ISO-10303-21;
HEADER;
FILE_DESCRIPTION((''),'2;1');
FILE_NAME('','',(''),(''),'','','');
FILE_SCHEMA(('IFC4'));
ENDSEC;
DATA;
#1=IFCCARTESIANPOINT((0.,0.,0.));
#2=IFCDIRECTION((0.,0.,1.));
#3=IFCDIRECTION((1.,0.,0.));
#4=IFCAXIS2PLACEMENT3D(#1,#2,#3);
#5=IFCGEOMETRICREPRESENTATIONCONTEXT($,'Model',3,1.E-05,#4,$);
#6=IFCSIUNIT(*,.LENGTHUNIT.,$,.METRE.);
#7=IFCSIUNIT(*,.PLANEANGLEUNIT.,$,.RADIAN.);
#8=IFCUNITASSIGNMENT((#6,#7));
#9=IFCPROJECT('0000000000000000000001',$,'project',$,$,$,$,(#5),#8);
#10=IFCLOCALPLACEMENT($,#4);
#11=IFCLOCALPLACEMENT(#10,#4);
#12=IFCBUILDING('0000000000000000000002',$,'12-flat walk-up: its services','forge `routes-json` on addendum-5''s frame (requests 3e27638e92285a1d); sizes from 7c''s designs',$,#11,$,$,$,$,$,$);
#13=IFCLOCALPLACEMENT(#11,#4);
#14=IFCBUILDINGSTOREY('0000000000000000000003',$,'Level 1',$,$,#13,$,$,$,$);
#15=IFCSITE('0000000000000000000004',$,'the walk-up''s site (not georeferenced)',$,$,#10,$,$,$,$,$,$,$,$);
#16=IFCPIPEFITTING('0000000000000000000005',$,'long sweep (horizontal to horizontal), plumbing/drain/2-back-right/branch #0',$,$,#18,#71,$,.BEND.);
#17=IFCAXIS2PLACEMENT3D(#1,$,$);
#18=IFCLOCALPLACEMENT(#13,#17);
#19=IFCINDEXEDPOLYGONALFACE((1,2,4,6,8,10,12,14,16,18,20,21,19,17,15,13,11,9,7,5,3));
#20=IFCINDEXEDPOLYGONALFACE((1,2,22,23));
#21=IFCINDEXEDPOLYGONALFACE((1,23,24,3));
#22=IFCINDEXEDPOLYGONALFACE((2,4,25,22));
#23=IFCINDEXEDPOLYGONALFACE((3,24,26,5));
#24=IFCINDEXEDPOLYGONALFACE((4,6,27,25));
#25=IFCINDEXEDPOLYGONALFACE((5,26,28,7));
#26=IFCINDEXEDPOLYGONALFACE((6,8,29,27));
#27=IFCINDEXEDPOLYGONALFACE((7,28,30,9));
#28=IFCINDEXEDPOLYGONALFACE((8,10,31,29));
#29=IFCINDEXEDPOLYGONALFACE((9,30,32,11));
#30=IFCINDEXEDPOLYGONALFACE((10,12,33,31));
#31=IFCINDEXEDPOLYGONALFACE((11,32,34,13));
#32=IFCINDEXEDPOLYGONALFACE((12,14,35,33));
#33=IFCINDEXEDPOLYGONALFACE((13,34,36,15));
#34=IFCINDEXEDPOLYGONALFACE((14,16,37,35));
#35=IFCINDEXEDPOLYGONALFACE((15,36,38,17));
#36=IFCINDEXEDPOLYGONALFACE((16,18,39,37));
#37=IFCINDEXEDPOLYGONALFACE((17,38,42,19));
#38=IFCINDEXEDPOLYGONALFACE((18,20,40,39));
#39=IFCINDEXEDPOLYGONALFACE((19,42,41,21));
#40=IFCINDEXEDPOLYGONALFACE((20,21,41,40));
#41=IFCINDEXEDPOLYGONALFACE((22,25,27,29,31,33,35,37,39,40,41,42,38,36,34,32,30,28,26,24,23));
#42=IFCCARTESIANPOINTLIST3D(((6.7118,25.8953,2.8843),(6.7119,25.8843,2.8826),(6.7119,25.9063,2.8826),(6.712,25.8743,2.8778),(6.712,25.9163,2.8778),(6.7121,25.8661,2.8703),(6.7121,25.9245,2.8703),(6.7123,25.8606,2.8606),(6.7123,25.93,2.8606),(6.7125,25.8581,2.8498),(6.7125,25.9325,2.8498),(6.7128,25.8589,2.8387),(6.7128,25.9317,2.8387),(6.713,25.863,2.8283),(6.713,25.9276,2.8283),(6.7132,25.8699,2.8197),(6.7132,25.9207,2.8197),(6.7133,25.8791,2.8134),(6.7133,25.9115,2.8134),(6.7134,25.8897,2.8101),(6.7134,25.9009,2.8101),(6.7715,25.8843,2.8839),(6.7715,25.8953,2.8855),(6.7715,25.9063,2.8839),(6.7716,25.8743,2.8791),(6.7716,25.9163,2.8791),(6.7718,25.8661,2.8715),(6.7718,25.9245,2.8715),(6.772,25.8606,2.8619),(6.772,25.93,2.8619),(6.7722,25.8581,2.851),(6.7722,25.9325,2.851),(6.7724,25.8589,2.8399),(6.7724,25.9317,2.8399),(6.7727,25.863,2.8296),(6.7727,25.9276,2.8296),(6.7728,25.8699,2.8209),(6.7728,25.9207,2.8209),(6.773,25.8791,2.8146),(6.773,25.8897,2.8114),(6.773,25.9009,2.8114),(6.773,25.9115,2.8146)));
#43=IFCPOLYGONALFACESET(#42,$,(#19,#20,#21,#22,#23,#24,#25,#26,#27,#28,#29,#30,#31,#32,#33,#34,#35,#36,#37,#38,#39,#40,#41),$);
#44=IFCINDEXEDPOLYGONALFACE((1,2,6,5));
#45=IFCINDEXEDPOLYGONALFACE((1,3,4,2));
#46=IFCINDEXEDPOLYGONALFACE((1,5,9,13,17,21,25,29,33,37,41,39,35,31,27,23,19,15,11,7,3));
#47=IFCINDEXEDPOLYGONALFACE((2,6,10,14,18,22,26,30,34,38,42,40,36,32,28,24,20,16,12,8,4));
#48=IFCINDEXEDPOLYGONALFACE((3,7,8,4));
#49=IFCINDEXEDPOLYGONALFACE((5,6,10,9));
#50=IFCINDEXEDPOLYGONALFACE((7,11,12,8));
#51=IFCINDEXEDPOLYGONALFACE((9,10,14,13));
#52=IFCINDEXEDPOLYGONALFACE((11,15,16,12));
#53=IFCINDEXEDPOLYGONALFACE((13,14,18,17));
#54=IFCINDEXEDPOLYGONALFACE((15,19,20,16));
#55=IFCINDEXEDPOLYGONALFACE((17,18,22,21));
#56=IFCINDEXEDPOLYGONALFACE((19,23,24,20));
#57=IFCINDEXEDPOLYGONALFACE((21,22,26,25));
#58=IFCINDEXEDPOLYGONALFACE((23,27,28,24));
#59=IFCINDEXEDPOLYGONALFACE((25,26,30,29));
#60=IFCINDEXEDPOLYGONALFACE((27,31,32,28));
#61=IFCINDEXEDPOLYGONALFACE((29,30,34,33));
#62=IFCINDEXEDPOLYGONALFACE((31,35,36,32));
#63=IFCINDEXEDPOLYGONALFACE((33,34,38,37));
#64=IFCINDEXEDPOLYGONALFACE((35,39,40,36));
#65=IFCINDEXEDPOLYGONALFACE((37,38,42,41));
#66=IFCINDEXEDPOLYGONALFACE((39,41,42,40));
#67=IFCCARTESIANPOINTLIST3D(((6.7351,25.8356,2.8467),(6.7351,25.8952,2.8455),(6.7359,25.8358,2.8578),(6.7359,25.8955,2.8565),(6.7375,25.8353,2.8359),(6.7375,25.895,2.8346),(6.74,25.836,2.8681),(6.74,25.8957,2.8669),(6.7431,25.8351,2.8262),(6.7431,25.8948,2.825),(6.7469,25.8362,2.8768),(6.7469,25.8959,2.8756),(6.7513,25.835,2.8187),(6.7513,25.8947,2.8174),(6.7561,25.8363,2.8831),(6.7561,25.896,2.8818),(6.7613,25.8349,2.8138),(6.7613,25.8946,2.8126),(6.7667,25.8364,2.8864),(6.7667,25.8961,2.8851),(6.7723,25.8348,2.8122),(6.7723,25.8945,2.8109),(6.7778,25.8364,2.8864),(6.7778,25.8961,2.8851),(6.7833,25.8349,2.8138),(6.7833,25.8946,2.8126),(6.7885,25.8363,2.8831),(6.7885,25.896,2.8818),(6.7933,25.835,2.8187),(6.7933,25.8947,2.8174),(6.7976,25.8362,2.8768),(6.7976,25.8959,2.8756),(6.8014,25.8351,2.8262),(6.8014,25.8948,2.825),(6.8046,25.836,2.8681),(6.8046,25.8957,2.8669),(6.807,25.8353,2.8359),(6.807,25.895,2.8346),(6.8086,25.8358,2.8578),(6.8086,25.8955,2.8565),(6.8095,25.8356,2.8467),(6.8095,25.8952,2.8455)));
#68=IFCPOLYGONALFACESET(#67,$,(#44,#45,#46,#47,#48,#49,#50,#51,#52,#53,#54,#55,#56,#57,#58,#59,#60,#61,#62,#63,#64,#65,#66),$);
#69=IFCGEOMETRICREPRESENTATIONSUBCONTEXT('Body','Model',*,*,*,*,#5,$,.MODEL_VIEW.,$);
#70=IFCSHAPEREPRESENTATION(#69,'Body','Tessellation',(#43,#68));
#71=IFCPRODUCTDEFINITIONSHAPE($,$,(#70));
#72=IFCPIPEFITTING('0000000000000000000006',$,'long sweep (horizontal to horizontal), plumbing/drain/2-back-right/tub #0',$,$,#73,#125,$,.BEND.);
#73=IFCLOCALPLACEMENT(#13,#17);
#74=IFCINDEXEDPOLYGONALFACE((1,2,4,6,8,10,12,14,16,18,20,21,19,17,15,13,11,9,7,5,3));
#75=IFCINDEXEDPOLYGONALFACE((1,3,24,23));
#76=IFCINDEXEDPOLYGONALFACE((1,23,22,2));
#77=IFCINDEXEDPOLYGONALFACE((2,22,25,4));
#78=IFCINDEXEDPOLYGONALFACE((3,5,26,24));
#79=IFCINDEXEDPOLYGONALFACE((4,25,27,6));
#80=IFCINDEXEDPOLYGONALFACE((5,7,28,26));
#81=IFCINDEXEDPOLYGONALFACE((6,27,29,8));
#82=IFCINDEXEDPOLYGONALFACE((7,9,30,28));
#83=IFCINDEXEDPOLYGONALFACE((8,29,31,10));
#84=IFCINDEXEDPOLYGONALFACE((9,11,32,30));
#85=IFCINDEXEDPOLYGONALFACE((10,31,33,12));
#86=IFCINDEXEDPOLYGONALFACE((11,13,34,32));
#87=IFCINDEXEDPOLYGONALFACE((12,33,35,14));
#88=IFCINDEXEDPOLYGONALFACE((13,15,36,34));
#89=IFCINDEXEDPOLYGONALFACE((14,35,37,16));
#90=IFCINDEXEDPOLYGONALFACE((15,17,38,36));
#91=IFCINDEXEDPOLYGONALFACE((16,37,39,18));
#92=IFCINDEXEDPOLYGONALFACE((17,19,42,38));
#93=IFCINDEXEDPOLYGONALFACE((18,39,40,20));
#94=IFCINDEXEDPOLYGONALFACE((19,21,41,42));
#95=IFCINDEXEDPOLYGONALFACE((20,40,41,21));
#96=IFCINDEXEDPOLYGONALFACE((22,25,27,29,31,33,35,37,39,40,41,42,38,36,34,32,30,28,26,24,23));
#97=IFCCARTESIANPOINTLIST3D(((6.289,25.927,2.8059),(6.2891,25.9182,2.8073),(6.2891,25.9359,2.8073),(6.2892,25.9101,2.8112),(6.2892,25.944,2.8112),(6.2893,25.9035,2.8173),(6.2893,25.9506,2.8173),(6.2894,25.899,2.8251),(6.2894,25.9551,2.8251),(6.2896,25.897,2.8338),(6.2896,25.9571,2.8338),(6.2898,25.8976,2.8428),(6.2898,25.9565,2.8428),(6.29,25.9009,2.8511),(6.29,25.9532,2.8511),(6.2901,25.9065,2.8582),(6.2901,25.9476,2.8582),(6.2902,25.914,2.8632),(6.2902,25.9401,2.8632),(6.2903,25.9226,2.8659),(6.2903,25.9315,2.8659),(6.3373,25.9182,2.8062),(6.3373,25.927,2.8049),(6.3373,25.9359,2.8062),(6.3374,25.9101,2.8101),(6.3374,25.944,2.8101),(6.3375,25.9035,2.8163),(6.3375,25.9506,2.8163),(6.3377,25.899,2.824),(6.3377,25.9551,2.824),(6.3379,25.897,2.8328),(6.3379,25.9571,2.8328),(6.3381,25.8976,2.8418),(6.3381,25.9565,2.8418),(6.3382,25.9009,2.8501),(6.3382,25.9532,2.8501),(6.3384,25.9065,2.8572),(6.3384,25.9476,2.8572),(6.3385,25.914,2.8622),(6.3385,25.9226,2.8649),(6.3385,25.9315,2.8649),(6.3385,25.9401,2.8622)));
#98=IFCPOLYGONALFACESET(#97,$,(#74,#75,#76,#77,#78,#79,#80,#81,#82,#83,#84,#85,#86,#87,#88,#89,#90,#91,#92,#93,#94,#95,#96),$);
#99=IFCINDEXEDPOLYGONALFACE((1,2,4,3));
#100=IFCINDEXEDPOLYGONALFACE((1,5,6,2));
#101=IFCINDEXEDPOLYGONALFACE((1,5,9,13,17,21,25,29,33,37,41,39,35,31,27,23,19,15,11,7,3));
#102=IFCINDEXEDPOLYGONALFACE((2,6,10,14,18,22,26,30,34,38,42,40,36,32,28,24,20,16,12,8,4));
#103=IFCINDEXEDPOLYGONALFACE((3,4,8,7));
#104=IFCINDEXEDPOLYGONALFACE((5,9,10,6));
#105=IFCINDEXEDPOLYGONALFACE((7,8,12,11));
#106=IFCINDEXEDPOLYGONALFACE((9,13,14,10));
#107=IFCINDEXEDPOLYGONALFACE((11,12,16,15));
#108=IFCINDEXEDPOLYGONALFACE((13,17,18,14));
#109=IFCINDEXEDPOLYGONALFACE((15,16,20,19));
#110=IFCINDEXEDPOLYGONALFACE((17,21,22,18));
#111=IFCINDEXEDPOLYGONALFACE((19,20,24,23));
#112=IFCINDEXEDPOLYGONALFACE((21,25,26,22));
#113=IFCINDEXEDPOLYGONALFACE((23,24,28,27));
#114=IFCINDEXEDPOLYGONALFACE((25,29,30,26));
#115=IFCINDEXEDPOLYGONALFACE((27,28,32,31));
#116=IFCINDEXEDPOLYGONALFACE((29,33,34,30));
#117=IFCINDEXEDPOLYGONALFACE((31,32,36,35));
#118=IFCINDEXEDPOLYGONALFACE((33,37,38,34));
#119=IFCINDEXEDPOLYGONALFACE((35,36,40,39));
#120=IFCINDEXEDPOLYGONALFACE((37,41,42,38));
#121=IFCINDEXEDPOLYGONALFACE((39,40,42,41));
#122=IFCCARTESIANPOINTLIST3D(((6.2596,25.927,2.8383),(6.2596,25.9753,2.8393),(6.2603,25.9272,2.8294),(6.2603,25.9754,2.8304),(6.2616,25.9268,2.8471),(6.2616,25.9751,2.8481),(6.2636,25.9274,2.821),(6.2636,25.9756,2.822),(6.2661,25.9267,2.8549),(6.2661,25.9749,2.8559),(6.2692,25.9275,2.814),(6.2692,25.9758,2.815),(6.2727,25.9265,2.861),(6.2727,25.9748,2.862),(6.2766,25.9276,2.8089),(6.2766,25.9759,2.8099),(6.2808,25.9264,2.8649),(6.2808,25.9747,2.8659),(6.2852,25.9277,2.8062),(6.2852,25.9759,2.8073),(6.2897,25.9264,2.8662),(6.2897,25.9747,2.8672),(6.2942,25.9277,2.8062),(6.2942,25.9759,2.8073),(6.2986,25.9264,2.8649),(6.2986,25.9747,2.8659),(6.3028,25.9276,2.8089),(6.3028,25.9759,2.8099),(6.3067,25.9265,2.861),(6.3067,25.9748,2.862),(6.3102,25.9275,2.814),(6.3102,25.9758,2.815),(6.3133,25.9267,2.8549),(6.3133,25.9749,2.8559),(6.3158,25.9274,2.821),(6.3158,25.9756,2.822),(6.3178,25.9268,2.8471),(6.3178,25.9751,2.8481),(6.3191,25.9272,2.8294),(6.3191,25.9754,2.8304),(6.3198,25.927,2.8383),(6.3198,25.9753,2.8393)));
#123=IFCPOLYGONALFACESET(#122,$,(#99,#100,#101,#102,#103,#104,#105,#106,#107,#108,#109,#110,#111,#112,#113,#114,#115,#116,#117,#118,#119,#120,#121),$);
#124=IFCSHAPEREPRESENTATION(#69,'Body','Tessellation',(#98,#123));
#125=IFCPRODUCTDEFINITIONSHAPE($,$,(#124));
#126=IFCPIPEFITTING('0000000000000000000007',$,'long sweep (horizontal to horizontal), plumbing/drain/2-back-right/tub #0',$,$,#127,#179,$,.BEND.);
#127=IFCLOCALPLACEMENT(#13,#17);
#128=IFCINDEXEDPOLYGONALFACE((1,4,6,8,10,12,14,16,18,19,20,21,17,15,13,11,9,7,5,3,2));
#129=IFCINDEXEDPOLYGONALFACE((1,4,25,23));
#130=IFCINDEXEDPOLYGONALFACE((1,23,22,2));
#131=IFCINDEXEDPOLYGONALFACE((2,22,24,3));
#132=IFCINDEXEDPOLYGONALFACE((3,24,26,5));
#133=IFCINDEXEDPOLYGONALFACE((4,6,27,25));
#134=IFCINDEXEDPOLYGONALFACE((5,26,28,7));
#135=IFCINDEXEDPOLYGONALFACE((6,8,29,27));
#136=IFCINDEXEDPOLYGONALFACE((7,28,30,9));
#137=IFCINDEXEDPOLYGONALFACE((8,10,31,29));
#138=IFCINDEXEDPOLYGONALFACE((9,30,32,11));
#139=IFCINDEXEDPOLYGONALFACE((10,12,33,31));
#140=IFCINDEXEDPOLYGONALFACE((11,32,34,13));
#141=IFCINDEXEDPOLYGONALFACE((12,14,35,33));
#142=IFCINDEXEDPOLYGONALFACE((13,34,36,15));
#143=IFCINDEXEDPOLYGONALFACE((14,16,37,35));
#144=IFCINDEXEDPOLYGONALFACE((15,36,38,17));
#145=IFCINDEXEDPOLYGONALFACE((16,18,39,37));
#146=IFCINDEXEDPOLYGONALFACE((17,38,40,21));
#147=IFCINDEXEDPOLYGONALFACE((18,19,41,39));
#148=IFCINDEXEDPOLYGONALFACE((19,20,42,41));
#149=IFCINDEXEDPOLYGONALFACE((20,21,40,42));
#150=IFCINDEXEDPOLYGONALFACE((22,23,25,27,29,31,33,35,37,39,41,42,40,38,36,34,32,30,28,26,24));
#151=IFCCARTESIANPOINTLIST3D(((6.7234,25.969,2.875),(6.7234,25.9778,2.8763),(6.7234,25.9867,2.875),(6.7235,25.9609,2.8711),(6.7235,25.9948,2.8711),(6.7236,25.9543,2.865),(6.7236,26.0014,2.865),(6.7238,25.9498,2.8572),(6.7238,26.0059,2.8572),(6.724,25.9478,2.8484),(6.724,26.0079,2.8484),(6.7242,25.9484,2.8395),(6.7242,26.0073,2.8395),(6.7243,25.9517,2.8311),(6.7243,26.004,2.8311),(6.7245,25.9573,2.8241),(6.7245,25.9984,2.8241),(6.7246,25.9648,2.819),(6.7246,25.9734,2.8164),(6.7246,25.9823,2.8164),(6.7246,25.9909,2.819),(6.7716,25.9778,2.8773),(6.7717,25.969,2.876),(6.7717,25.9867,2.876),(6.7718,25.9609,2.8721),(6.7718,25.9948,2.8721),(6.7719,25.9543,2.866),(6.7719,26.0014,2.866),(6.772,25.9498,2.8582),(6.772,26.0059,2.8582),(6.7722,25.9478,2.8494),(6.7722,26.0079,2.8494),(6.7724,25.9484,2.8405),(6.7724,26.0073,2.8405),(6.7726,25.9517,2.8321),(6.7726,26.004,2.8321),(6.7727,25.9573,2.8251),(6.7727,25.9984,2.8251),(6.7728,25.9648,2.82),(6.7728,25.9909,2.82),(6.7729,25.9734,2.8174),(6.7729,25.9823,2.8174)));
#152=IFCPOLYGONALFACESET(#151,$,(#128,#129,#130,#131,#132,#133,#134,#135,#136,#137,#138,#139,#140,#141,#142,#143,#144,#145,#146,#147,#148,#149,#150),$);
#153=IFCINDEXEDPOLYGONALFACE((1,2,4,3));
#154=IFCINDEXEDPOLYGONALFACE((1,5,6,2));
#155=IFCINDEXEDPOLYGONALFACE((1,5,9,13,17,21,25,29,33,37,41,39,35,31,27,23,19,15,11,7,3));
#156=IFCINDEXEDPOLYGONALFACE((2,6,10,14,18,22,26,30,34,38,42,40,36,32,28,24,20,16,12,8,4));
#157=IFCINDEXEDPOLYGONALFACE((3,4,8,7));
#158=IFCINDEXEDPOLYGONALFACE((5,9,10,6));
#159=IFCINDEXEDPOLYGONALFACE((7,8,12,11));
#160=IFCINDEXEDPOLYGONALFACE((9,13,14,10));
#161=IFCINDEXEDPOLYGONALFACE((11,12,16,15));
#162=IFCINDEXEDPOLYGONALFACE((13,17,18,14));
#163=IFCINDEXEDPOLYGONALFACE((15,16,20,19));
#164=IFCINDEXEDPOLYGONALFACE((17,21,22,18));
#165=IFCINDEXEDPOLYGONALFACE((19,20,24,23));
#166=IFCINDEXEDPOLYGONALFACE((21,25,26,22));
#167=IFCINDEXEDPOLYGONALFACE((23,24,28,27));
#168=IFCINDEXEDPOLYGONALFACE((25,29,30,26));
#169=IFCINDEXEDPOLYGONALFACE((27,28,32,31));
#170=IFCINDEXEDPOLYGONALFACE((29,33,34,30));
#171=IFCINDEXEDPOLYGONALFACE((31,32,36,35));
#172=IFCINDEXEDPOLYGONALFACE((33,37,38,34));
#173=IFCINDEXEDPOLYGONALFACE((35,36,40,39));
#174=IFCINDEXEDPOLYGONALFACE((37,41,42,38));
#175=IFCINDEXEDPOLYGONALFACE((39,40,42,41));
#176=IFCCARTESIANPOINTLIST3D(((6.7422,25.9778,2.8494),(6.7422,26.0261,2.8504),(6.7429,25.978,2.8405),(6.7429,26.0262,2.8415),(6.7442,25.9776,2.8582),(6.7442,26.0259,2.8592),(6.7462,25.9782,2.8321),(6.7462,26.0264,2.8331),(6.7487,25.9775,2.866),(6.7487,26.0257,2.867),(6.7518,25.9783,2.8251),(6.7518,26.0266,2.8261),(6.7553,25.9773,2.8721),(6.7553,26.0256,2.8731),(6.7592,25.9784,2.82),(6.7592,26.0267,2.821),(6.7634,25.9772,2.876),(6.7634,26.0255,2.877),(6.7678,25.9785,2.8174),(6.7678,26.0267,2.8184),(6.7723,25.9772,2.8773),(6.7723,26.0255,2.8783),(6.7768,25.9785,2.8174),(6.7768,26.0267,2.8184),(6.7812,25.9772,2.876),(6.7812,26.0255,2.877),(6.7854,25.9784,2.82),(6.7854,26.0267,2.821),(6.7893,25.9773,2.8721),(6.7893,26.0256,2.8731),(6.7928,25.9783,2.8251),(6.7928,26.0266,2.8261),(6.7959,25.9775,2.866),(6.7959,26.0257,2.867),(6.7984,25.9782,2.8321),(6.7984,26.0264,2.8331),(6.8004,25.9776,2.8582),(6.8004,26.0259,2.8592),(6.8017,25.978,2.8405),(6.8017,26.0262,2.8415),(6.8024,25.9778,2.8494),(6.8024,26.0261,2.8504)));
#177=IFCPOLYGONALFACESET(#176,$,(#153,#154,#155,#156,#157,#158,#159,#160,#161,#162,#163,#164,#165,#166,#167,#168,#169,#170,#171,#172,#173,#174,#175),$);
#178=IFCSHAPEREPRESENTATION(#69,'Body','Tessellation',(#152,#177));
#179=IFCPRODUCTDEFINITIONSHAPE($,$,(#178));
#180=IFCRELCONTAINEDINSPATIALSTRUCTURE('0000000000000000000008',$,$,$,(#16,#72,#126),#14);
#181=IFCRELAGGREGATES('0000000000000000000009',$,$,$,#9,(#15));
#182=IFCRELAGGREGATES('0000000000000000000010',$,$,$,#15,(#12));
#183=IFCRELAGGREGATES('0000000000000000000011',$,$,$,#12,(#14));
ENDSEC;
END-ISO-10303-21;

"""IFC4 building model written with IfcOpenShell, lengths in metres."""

from ifc_helpers import new_model, entity, si_unit, frame, origin_with_axes, place, context, subcontext, project, spatial, element, save


model = new_model("IFC4")

# Units and contexts
model_context = context("Model", 3, precision=1e-05, world=origin_with_axes())
body_context = subcontext(model_context, "Body", "Model", "MODEL_VIEW")
ifc_project = project(units=[si_unit("LENGTHUNIT", "METRE"), si_unit("PLANEANGLEUNIT", "RADIAN")], contexts=[model_context])

# Site, building, storey
site_placement = place(None, origin_with_axes())
site = spatial("IfcSite", under=ifc_project, at=site_placement, Name="the walk-up's site (not georeferenced)")
building_placement = place(site_placement, origin_with_axes())
building = spatial("IfcBuilding", under=site, at=building_placement, Name="12-flat walk-up: its services", Description="forge `routes-json` on addendum-5's frame (requests 3e27638e92285a1d); sizes from 7c's designs")
storey_placement = place(building_placement, origin_with_axes())
storey = spatial("IfcBuildingStorey", under=building, at=storey_placement, Name="Level 1")

# Pipe fittings
pipe_fitting_1_placement = place(storey_placement, frame((6.7126, 25.8953, 2.847), z_axis=(0.0, 0.0, 1.0), x_axis=(1.0, 0.0, 0.0)))
element("IfcPipeFitting", 1, at=pipe_fitting_1_placement, inside=storey, Name="long sweep (horizontal to horizontal), plumbing/drain/2-back-right/branch #0", PredefinedType="BEND", context=body_context, shape_type="AdvancedSweptSolid", body=[
    entity("IfcSweptDiskSolid", entity("IfcPolyline", [entity("IfcCartesianPoint", [0.0, 0.0, 0.0]), entity("IfcCartesianPoint", [0.0597, 0.0, 0.0012])]), 0.0373),
    entity("IfcSweptDiskSolid", entity("IfcPolyline", [entity("IfcCartesianPoint", [0.0597, 0.0, 0.0012]), entity("IfcCartesianPoint", [0.0597, -0.0597, 0.0025])]), 0.0373),
])
pipe_fitting_2_placement = place(storey_placement, frame((6.3379, 25.9271, 2.8351), z_axis=(0.0, 0.0, 1.0), x_axis=(1.0, 0.0, 0.0)))
element("IfcPipeFitting", 2, at=pipe_fitting_2_placement, inside=storey, Name="long sweep (horizontal to horizontal), plumbing/drain/2-back-right/tub #0", PredefinedType="BEND", context=body_context, shape_type="AdvancedSweptSolid", body=[
    entity("IfcSweptDiskSolid", entity("IfcPolyline", [entity("IfcCartesianPoint", [0.0, 0.0, 0.0]), entity("IfcCartesianPoint", [-0.0482, 0.0, 0.001])]), 0.0302),
    entity("IfcSweptDiskSolid", entity("IfcPolyline", [entity("IfcCartesianPoint", [-0.0482, 0.0, 0.001]), entity("IfcCartesianPoint", [-0.0482, 0.0482, 0.002])]), 0.0302),
])
pipe_fitting_3_placement = place(storey_placement, frame((6.724, 25.9779, 2.8462), z_axis=(0.0, 0.0, 1.0), x_axis=(1.0, 0.0, 0.0)))
element("IfcPipeFitting", 3, at=pipe_fitting_3_placement, inside=storey, Name="long sweep (horizontal to horizontal), plumbing/drain/2-back-right/tub #0", PredefinedType="BEND", context=body_context, shape_type="AdvancedSweptSolid", body=[
    entity("IfcSweptDiskSolid", entity("IfcPolyline", [entity("IfcCartesianPoint", [0.0, 0.0, 0.0]), entity("IfcCartesianPoint", [0.0482, 0.0, 0.001])]), 0.0302),
    entity("IfcSweptDiskSolid", entity("IfcPolyline", [entity("IfcCartesianPoint", [0.0482, 0.0, 0.001]), entity("IfcCartesianPoint", [0.0482, 0.0482, 0.002])]), 0.0302),
])

save(model, "model.ifc")
